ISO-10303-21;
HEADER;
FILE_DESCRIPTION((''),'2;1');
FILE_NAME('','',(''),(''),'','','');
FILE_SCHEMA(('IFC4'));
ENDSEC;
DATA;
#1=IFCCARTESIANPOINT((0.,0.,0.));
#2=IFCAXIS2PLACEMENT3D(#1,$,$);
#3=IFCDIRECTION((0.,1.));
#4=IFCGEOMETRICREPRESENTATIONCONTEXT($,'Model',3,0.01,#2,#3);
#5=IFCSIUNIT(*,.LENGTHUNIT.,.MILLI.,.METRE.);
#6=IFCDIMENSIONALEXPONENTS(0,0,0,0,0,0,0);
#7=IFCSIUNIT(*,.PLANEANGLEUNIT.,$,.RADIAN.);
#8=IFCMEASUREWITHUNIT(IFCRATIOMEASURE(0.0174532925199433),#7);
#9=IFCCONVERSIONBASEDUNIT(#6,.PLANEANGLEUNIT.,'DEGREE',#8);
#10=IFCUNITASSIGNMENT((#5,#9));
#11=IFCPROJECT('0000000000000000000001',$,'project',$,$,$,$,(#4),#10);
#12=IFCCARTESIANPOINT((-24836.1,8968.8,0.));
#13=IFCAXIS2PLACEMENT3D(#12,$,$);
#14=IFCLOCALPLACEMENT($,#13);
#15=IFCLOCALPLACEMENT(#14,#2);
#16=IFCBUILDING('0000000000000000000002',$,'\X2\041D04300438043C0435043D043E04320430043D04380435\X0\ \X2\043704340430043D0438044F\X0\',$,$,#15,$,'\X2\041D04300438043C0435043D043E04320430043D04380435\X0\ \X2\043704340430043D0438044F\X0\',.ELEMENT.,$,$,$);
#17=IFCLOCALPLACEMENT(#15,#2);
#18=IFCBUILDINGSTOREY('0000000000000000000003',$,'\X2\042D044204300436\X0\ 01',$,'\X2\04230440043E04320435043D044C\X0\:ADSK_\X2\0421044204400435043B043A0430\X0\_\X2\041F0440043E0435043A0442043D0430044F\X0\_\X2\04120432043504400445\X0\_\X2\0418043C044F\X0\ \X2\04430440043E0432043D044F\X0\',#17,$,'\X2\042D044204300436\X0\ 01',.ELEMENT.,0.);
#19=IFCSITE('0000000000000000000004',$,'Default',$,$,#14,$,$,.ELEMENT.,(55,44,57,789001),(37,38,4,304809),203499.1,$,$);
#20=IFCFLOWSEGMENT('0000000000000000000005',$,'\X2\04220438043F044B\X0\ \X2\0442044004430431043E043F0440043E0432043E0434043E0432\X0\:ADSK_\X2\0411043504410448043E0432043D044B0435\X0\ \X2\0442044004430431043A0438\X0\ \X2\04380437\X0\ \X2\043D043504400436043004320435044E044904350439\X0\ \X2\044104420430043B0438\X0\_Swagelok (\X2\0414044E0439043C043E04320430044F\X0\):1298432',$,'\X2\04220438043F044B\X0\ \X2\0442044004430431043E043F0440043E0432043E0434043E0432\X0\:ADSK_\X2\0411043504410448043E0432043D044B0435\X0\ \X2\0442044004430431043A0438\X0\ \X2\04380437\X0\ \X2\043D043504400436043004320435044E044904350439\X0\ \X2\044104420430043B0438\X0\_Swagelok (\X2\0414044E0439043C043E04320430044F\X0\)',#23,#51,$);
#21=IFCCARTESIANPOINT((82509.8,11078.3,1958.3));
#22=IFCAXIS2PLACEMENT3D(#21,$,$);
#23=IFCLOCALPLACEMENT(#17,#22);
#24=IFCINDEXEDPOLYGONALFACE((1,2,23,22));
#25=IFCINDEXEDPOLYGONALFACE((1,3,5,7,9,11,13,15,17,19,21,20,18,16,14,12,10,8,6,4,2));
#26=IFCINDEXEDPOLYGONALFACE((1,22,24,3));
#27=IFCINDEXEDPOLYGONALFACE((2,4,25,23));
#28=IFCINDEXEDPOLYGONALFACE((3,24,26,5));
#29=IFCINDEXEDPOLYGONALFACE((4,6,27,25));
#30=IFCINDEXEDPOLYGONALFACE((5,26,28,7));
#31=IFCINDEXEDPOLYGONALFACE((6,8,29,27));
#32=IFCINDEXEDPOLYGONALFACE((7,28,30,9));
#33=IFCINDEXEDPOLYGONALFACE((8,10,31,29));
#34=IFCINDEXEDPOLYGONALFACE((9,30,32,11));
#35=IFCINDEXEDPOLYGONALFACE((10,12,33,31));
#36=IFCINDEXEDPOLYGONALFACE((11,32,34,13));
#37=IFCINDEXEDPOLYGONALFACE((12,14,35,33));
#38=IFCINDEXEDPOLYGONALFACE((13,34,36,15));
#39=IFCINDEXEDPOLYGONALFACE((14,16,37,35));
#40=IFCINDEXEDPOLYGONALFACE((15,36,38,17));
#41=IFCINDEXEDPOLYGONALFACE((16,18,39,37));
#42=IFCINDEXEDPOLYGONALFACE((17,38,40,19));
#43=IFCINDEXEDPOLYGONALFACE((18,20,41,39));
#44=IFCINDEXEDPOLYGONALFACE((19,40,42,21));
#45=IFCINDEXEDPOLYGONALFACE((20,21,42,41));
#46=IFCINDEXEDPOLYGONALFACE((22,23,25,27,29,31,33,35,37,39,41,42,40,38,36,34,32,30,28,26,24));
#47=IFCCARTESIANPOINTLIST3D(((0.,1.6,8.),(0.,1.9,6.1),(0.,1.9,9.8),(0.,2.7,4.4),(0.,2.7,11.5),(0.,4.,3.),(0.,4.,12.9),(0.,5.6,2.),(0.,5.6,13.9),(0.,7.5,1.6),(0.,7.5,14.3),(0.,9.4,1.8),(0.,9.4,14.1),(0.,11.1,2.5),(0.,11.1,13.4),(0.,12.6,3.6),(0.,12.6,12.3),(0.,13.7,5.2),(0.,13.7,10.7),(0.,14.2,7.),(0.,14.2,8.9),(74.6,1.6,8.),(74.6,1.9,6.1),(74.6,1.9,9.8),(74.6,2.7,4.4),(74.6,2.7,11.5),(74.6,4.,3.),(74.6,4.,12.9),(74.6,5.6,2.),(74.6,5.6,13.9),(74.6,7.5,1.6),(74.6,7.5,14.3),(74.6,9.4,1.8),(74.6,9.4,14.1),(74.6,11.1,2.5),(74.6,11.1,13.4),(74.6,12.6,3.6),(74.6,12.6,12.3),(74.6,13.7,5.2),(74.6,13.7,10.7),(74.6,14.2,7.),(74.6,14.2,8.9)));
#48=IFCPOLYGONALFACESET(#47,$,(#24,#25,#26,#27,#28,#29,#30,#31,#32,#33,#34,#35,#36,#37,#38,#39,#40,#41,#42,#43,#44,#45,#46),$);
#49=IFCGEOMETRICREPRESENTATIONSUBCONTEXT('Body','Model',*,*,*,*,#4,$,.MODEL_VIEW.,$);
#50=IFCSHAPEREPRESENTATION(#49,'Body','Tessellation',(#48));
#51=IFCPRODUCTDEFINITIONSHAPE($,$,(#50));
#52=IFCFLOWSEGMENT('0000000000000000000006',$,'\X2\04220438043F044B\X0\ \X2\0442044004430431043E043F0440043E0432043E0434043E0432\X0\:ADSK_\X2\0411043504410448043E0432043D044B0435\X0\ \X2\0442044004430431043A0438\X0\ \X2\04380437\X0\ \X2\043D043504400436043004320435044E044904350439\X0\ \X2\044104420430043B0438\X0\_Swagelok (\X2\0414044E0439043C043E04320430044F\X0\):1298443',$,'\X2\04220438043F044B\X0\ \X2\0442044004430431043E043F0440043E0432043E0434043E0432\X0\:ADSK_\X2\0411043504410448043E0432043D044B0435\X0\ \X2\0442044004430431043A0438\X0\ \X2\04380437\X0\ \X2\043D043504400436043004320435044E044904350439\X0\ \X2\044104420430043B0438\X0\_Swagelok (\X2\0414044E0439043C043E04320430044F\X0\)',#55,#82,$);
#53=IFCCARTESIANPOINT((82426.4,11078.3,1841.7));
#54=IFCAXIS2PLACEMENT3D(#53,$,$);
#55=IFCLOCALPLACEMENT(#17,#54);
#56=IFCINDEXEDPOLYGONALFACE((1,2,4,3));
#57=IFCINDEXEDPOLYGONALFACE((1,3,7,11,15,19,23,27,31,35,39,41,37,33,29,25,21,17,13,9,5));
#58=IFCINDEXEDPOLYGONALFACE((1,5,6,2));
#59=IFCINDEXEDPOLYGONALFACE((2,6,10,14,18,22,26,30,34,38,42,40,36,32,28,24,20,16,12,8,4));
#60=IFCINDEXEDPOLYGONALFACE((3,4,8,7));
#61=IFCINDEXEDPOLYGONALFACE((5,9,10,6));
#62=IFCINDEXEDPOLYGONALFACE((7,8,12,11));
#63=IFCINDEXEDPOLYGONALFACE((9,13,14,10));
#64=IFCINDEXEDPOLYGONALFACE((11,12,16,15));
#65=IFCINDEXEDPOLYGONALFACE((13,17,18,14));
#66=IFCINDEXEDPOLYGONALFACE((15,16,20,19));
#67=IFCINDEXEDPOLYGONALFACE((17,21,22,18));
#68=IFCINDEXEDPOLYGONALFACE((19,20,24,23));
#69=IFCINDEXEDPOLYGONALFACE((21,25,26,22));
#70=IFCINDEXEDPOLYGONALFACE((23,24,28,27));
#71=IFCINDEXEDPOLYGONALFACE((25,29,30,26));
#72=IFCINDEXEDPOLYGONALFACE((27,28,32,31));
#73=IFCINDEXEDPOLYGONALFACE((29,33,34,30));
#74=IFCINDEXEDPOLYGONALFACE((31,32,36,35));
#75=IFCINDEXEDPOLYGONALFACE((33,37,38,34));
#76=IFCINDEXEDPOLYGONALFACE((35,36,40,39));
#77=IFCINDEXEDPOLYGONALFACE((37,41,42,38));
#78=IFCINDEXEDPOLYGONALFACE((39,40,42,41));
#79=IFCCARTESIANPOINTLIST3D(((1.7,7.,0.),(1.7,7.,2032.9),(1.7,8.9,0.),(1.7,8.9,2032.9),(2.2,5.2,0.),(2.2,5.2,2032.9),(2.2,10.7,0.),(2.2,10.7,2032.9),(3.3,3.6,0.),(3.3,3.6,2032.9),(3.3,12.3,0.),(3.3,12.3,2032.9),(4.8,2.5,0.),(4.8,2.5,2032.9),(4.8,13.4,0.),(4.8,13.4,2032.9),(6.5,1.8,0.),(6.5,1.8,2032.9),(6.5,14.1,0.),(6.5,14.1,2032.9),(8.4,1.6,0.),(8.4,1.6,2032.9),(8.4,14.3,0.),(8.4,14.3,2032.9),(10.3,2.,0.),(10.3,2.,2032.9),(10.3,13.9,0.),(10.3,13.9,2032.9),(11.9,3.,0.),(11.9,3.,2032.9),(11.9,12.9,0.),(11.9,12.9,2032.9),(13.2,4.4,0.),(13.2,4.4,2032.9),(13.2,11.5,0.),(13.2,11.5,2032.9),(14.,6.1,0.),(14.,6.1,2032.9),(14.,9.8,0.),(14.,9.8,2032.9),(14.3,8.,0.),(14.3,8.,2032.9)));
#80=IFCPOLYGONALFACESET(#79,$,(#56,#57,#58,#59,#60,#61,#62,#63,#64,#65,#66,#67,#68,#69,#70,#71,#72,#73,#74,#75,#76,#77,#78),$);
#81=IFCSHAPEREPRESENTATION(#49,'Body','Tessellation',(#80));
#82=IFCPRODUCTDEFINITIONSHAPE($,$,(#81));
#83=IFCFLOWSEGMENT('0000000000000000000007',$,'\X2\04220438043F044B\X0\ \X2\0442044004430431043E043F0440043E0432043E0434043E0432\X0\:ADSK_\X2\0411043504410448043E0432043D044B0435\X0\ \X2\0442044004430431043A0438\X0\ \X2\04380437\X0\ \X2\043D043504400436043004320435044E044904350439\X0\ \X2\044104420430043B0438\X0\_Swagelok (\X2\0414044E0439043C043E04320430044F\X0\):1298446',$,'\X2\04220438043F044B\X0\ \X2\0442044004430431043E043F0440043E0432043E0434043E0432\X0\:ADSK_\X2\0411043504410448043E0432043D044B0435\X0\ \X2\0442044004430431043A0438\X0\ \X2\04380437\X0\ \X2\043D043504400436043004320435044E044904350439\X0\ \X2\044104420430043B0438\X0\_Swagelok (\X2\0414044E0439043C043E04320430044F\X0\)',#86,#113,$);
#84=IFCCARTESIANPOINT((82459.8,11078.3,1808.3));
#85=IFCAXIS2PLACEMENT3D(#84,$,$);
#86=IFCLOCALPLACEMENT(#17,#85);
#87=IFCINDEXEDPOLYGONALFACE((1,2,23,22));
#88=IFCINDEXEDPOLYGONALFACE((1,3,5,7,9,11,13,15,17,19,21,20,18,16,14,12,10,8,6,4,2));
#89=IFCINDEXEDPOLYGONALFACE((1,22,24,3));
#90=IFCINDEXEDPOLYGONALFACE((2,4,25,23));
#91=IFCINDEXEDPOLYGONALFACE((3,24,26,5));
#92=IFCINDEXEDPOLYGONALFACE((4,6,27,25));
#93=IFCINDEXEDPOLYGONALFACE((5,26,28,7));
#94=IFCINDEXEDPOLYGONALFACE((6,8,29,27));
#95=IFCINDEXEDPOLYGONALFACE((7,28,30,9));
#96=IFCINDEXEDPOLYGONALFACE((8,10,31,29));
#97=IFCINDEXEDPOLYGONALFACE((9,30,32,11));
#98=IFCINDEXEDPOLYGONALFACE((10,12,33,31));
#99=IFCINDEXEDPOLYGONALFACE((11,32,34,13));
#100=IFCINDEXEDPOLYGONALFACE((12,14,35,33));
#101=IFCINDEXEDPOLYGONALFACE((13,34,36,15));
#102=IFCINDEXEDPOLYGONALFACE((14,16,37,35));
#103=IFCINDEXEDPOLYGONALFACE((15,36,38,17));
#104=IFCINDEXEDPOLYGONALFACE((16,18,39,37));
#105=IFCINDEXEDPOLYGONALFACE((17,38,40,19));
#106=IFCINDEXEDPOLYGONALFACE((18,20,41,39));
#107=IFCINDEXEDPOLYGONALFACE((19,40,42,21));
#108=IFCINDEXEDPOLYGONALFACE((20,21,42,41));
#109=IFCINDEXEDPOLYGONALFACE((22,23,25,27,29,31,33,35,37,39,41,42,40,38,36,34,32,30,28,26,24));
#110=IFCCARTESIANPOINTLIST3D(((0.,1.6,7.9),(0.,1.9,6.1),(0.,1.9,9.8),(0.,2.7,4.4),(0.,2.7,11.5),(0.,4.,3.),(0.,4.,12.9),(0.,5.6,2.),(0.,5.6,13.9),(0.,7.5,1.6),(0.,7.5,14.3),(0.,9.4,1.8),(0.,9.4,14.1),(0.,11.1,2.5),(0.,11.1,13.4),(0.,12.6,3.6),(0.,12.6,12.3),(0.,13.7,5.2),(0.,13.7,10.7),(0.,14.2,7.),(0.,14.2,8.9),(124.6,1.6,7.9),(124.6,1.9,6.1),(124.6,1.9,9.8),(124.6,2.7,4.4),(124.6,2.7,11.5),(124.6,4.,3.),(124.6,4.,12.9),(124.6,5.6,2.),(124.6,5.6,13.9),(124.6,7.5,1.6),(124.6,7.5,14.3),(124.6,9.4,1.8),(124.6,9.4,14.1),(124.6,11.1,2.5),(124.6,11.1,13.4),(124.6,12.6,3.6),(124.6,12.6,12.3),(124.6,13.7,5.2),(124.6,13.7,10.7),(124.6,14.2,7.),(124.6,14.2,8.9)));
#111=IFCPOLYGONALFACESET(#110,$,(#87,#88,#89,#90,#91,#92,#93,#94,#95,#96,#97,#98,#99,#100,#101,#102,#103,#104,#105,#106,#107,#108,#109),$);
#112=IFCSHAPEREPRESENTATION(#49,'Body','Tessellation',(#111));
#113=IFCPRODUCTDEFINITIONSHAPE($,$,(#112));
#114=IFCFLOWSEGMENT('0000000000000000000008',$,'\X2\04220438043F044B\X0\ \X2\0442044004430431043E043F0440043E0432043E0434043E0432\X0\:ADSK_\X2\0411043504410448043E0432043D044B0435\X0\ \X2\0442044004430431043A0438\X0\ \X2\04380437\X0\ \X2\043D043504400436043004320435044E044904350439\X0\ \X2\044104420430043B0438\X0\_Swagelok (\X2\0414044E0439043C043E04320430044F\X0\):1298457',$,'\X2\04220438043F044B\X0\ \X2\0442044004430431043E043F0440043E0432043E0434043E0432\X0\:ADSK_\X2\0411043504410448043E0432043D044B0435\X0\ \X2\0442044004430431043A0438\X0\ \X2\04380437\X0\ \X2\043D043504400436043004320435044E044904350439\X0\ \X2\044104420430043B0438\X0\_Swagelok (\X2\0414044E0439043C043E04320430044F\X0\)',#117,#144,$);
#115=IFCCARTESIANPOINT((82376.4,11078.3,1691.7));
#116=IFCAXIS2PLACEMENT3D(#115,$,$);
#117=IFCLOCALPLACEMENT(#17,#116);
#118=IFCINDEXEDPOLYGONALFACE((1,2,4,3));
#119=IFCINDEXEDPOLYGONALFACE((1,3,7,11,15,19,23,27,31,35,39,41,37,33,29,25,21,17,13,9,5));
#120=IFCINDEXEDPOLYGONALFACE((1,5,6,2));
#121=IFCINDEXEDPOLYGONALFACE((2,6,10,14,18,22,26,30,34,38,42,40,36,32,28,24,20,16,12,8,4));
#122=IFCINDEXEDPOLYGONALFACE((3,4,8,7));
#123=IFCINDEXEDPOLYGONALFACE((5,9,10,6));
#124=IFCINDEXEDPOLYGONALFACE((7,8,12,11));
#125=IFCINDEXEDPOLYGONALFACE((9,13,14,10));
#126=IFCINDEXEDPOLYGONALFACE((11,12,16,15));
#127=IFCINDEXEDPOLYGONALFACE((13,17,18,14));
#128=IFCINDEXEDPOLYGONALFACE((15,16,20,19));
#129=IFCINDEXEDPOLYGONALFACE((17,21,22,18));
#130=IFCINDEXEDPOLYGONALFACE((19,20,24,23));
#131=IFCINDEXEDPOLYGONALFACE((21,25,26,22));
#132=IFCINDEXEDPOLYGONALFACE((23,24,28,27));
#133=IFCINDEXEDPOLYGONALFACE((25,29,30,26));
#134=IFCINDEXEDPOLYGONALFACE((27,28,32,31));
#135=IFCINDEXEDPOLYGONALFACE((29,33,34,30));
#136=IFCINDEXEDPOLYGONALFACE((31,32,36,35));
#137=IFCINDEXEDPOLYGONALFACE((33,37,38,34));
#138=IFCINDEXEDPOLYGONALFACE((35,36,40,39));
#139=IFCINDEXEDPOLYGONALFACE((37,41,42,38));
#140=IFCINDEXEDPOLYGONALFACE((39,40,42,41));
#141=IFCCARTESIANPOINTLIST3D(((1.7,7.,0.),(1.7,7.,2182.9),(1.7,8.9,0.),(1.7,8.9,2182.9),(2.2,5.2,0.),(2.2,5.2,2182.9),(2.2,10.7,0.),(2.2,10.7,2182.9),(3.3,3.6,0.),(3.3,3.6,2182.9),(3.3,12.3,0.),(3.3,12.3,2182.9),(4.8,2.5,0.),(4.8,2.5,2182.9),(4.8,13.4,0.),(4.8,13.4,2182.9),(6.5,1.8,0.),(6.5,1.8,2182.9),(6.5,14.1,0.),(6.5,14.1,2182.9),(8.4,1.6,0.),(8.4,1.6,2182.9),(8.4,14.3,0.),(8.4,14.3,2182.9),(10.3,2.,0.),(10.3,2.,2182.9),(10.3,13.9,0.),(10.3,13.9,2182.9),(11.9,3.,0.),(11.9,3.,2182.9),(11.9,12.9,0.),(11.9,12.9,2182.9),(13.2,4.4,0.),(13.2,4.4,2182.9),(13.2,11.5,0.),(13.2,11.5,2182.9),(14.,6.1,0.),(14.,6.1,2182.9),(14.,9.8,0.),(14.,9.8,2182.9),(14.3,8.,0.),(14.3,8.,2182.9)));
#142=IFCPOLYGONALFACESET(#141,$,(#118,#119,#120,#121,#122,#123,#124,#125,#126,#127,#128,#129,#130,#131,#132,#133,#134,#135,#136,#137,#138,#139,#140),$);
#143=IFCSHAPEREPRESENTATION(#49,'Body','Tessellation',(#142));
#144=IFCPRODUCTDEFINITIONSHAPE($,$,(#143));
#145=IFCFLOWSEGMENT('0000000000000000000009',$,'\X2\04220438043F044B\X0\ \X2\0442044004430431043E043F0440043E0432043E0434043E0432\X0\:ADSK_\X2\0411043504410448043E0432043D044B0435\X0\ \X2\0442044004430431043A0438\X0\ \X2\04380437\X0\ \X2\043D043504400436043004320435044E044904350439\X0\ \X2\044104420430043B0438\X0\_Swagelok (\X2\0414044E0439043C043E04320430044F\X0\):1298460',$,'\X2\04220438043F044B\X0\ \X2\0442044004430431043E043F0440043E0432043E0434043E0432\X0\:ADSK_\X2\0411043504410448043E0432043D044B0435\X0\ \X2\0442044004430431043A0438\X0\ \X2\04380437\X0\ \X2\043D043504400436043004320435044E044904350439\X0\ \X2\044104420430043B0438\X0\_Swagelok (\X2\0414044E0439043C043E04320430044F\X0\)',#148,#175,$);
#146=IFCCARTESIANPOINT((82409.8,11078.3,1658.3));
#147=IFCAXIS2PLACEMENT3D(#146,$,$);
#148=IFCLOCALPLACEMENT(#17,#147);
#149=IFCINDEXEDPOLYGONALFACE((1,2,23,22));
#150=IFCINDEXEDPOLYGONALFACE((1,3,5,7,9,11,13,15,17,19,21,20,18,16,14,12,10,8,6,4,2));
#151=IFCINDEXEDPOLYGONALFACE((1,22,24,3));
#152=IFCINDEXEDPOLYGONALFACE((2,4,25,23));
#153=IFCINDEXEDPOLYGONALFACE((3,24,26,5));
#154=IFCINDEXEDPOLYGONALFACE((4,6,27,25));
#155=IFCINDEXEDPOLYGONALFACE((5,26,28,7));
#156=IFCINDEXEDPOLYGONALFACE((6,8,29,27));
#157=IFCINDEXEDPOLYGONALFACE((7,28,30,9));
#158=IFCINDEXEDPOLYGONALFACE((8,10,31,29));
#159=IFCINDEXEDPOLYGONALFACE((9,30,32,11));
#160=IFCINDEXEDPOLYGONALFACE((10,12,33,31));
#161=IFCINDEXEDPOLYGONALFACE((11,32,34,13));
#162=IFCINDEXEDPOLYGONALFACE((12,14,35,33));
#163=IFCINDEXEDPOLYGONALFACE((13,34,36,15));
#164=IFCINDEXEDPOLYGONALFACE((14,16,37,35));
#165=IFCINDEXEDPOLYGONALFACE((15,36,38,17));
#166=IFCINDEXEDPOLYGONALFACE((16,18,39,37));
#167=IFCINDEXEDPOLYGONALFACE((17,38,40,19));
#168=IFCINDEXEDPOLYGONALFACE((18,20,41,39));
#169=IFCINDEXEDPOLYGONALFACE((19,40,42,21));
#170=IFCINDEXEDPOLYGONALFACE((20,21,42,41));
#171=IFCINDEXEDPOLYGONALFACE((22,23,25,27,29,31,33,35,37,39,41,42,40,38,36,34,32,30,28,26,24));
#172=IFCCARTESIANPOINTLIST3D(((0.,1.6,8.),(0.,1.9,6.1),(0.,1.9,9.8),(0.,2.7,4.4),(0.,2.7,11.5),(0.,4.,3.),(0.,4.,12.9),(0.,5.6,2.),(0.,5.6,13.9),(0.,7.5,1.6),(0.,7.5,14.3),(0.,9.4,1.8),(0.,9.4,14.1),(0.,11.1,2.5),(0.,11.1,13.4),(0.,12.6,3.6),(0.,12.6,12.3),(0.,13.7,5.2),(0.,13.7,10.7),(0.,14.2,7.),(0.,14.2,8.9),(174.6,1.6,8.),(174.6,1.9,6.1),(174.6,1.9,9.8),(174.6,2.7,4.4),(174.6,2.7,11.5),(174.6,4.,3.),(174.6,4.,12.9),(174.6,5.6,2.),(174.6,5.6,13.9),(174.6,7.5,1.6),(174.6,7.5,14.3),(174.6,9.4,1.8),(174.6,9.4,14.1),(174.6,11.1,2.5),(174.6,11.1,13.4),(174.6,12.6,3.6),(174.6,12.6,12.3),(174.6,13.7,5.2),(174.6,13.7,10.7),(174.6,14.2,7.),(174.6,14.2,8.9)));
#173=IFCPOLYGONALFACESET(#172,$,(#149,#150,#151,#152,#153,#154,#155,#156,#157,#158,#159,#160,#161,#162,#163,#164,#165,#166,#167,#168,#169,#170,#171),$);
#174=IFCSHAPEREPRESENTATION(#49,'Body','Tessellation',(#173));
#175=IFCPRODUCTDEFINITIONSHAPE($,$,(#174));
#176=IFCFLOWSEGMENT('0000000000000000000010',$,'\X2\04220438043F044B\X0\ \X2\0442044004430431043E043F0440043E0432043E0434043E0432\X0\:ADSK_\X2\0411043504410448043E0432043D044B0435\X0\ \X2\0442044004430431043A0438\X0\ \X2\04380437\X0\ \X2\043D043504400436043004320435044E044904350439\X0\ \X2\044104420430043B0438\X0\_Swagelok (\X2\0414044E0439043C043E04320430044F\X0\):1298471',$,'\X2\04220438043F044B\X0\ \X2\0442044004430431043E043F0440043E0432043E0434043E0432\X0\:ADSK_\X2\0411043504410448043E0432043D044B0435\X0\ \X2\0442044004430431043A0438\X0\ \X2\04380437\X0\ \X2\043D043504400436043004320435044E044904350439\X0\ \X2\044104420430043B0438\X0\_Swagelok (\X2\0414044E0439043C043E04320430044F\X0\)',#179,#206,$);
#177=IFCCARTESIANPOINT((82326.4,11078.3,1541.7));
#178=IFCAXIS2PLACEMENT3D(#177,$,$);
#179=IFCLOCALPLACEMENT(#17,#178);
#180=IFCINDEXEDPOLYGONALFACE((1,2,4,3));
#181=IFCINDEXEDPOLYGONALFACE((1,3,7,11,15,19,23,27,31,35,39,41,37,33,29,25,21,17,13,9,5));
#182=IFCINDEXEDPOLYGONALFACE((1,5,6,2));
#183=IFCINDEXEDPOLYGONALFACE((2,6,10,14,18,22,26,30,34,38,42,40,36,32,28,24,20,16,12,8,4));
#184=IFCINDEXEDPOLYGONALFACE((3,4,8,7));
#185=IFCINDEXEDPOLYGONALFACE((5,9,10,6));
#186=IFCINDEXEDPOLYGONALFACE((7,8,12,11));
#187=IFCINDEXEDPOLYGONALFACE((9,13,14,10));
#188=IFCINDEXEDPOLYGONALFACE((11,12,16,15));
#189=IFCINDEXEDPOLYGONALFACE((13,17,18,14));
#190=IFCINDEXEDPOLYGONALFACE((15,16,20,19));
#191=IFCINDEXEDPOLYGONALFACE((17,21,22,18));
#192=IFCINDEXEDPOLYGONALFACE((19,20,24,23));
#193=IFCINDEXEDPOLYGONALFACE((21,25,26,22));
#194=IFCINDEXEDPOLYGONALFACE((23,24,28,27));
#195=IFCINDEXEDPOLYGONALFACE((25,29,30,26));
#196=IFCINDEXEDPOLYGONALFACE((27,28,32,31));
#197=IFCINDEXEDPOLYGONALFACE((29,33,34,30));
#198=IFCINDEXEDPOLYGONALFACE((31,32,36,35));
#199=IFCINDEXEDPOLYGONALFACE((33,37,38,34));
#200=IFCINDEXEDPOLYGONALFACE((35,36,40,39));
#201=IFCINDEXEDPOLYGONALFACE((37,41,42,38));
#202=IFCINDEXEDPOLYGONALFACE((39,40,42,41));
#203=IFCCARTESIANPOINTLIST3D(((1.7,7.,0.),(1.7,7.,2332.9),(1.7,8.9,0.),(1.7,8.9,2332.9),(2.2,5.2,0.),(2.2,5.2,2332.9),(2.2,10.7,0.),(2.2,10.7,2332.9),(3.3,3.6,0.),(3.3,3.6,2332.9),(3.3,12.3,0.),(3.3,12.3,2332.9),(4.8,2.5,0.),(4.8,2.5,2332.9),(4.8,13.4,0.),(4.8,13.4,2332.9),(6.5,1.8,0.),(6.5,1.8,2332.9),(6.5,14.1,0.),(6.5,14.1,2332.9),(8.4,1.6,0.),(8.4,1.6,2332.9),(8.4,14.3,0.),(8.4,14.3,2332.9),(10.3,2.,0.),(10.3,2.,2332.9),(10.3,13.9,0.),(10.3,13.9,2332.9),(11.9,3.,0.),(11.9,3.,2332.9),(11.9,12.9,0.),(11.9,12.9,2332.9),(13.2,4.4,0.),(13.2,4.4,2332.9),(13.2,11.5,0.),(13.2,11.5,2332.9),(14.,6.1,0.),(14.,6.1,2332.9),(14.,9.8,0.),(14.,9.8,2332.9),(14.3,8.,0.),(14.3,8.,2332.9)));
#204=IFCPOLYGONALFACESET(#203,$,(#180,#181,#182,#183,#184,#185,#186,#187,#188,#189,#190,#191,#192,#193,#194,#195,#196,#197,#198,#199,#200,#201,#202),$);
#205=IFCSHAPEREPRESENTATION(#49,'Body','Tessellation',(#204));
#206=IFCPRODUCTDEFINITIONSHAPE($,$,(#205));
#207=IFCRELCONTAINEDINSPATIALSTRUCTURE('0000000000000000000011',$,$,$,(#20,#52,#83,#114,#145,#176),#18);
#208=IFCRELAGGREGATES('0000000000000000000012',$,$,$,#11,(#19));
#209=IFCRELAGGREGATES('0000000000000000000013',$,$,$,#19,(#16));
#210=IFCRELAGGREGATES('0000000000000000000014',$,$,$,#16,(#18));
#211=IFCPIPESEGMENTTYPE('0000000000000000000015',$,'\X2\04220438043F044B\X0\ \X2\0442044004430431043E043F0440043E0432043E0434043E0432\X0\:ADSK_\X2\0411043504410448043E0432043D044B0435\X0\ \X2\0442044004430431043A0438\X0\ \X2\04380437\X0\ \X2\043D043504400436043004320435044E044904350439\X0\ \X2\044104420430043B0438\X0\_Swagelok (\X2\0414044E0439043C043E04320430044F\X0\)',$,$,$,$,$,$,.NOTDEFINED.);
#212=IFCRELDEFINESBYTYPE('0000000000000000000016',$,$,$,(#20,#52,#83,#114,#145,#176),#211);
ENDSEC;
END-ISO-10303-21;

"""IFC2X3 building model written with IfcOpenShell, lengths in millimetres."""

from ifc_helpers import new_model, entity, si_unit, converted_unit, direction, frame, origin, origin_2d_with_axis, place, context, subcontext, project, spatial, circle, extrude, type_object, element, save


model = new_model("IFC2X3")

# Units and contexts
model_context = context("Model", 3, precision=0.01, world=origin(), true_north=direction((0.0, 1.0)))
body_context = subcontext(model_context, "Body", "Model", "MODEL_VIEW")
ifc_project = project(units=[si_unit("LENGTHUNIT", "METRE", prefix="MILLI"), converted_unit("PLANEANGLEUNIT", "DEGREE", entity("IfcRatioMeasure", 0.0174532925199433), si_unit("PLANEANGLEUNIT", "RADIAN"), dimensions=[0, 0, 0, 0, 0, 0, 0])], contexts=[model_context])

# Site, building, storey
site_placement = place(None, frame((-24836.1, 8968.8, 0.0)))
site = spatial("IfcSite", under=ifc_project, at=site_placement, Name="Default", CompositionType="ELEMENT", RefLatitude=(55, 44, 57, 789001), RefLongitude=(37, 38, 4, 304809), RefElevation=203499.1)
building_placement = place(site_placement, origin())
building = spatial("IfcBuilding", under=site, at=building_placement, Name="Наименование здания", LongName="Наименование здания", CompositionType="ELEMENT")
storey_placement = place(building_placement, origin())
storey = spatial("IfcBuildingStorey", under=building, at=storey_placement, Name="Этаж 01", ObjectType="Уровень:ADSK_Стрелка_Проектная_Вверх_Имя уровня", LongName="Этаж 01", CompositionType="ELEMENT", Elevation=0.0)

# Flow segments
pipe_segment_type = type_object("IfcPipeSegmentType", Name="Типы трубопроводов:ADSK_Бесшовные трубки из нержавеющей стали_Swagelok (Дюймовая)", PredefinedType="NOTDEFINED")
flow_segment_1_placement = place(storey_placement, frame((82509.8, 11078.3, 1958.3)))
element("IfcFlowSegment", 1, at=flow_segment_1_placement, inside=storey, type_object=pipe_segment_type, Name="Типы трубопроводов:ADSK_Бесшовные трубки из нержавеющей стали_Swagelok (Дюймовая):1298432", ObjectType="Типы трубопроводов:ADSK_Бесшовные трубки из нержавеющей стали_Swagelok (Дюймовая)", context=body_context, shape_type="SweptSolid", body=[
    extrude(circle(Radius=6.3, at=origin_2d_with_axis()), frame((0.0, 8.0, 8.0), z_axis=(1.0, 0.0, 0.0), x_axis=(0.0, -1.0, 0.0)), (0.0, 0.0, 1.0), 74.6),
])
flow_segment_2_placement = place(storey_placement, frame((82426.4, 11078.3, 1841.7)))
element("IfcFlowSegment", 2, at=flow_segment_2_placement, inside=storey, type_object=pipe_segment_type, Name="Типы трубопроводов:ADSK_Бесшовные трубки из нержавеющей стали_Swagelok (Дюймовая):1298443", ObjectType="Типы трубопроводов:ADSK_Бесшовные трубки из нержавеющей стали_Swagelok (Дюймовая)", context=body_context, shape_type="SweptSolid", body=[
    extrude(circle(Radius=6.3, at=origin_2d_with_axis()), frame((8.0, 8.0, 0.0)), (0.0, 0.0, 1.0), 2032.9),
])
flow_segment_3_placement = place(storey_placement, frame((82459.8, 11078.3, 1808.3)))
element("IfcFlowSegment", 3, at=flow_segment_3_placement, inside=storey, type_object=pipe_segment_type, Name="Типы трубопроводов:ADSK_Бесшовные трубки из нержавеющей стали_Swagelok (Дюймовая):1298446", ObjectType="Типы трубопроводов:ADSK_Бесшовные трубки из нержавеющей стали_Swagelok (Дюймовая)", context=body_context, shape_type="SweptSolid", body=[
    extrude(circle(Radius=6.3, at=origin_2d_with_axis()), frame((0.0, 8.0, 8.0), z_axis=(1.0, 0.0, 0.0), x_axis=(0.0, -1.0, 0.0)), (0.0, 0.0, 1.0), 124.6),
])
flow_segment_4_placement = place(storey_placement, frame((82376.4, 11078.3, 1691.7)))
element("IfcFlowSegment", 4, at=flow_segment_4_placement, inside=storey, type_object=pipe_segment_type, Name="Типы трубопроводов:ADSK_Бесшовные трубки из нержавеющей стали_Swagelok (Дюймовая):1298457", ObjectType="Типы трубопроводов:ADSK_Бесшовные трубки из нержавеющей стали_Swagelok (Дюймовая)", context=body_context, shape_type="SweptSolid", body=[
    extrude(circle(Radius=6.3, at=origin_2d_with_axis()), frame((8.0, 8.0, 0.0)), (0.0, 0.0, 1.0), 2182.9),
])
flow_segment_5_placement = place(storey_placement, frame((82409.8, 11078.3, 1658.3)))
element("IfcFlowSegment", 5, at=flow_segment_5_placement, inside=storey, type_object=pipe_segment_type, Name="Типы трубопроводов:ADSK_Бесшовные трубки из нержавеющей стали_Swagelok (Дюймовая):1298460", ObjectType="Типы трубопроводов:ADSK_Бесшовные трубки из нержавеющей стали_Swagelok (Дюймовая)", context=body_context, shape_type="SweptSolid", body=[
    extrude(circle(Radius=6.3, at=origin_2d_with_axis()), frame((0.0, 8.0, 8.0), z_axis=(1.0, 0.0, 0.0), x_axis=(0.0, -1.0, 0.0)), (0.0, 0.0, 1.0), 174.6),
])
flow_segment_6_placement = place(storey_placement, frame((82326.4, 11078.3, 1541.7)))
element("IfcFlowSegment", 6, at=flow_segment_6_placement, inside=storey, type_object=pipe_segment_type, Name="Типы трубопроводов:ADSK_Бесшовные трубки из нержавеющей стали_Swagelok (Дюймовая):1298471", ObjectType="Типы трубопроводов:ADSK_Бесшовные трубки из нержавеющей стали_Swagelok (Дюймовая)", context=body_context, shape_type="SweptSolid", body=[
    extrude(circle(Radius=6.3, at=origin_2d_with_axis()), frame((8.0, 8.0, 0.0)), (0.0, 0.0, 1.0), 2332.9),
])

save(model, "model.ifc")
